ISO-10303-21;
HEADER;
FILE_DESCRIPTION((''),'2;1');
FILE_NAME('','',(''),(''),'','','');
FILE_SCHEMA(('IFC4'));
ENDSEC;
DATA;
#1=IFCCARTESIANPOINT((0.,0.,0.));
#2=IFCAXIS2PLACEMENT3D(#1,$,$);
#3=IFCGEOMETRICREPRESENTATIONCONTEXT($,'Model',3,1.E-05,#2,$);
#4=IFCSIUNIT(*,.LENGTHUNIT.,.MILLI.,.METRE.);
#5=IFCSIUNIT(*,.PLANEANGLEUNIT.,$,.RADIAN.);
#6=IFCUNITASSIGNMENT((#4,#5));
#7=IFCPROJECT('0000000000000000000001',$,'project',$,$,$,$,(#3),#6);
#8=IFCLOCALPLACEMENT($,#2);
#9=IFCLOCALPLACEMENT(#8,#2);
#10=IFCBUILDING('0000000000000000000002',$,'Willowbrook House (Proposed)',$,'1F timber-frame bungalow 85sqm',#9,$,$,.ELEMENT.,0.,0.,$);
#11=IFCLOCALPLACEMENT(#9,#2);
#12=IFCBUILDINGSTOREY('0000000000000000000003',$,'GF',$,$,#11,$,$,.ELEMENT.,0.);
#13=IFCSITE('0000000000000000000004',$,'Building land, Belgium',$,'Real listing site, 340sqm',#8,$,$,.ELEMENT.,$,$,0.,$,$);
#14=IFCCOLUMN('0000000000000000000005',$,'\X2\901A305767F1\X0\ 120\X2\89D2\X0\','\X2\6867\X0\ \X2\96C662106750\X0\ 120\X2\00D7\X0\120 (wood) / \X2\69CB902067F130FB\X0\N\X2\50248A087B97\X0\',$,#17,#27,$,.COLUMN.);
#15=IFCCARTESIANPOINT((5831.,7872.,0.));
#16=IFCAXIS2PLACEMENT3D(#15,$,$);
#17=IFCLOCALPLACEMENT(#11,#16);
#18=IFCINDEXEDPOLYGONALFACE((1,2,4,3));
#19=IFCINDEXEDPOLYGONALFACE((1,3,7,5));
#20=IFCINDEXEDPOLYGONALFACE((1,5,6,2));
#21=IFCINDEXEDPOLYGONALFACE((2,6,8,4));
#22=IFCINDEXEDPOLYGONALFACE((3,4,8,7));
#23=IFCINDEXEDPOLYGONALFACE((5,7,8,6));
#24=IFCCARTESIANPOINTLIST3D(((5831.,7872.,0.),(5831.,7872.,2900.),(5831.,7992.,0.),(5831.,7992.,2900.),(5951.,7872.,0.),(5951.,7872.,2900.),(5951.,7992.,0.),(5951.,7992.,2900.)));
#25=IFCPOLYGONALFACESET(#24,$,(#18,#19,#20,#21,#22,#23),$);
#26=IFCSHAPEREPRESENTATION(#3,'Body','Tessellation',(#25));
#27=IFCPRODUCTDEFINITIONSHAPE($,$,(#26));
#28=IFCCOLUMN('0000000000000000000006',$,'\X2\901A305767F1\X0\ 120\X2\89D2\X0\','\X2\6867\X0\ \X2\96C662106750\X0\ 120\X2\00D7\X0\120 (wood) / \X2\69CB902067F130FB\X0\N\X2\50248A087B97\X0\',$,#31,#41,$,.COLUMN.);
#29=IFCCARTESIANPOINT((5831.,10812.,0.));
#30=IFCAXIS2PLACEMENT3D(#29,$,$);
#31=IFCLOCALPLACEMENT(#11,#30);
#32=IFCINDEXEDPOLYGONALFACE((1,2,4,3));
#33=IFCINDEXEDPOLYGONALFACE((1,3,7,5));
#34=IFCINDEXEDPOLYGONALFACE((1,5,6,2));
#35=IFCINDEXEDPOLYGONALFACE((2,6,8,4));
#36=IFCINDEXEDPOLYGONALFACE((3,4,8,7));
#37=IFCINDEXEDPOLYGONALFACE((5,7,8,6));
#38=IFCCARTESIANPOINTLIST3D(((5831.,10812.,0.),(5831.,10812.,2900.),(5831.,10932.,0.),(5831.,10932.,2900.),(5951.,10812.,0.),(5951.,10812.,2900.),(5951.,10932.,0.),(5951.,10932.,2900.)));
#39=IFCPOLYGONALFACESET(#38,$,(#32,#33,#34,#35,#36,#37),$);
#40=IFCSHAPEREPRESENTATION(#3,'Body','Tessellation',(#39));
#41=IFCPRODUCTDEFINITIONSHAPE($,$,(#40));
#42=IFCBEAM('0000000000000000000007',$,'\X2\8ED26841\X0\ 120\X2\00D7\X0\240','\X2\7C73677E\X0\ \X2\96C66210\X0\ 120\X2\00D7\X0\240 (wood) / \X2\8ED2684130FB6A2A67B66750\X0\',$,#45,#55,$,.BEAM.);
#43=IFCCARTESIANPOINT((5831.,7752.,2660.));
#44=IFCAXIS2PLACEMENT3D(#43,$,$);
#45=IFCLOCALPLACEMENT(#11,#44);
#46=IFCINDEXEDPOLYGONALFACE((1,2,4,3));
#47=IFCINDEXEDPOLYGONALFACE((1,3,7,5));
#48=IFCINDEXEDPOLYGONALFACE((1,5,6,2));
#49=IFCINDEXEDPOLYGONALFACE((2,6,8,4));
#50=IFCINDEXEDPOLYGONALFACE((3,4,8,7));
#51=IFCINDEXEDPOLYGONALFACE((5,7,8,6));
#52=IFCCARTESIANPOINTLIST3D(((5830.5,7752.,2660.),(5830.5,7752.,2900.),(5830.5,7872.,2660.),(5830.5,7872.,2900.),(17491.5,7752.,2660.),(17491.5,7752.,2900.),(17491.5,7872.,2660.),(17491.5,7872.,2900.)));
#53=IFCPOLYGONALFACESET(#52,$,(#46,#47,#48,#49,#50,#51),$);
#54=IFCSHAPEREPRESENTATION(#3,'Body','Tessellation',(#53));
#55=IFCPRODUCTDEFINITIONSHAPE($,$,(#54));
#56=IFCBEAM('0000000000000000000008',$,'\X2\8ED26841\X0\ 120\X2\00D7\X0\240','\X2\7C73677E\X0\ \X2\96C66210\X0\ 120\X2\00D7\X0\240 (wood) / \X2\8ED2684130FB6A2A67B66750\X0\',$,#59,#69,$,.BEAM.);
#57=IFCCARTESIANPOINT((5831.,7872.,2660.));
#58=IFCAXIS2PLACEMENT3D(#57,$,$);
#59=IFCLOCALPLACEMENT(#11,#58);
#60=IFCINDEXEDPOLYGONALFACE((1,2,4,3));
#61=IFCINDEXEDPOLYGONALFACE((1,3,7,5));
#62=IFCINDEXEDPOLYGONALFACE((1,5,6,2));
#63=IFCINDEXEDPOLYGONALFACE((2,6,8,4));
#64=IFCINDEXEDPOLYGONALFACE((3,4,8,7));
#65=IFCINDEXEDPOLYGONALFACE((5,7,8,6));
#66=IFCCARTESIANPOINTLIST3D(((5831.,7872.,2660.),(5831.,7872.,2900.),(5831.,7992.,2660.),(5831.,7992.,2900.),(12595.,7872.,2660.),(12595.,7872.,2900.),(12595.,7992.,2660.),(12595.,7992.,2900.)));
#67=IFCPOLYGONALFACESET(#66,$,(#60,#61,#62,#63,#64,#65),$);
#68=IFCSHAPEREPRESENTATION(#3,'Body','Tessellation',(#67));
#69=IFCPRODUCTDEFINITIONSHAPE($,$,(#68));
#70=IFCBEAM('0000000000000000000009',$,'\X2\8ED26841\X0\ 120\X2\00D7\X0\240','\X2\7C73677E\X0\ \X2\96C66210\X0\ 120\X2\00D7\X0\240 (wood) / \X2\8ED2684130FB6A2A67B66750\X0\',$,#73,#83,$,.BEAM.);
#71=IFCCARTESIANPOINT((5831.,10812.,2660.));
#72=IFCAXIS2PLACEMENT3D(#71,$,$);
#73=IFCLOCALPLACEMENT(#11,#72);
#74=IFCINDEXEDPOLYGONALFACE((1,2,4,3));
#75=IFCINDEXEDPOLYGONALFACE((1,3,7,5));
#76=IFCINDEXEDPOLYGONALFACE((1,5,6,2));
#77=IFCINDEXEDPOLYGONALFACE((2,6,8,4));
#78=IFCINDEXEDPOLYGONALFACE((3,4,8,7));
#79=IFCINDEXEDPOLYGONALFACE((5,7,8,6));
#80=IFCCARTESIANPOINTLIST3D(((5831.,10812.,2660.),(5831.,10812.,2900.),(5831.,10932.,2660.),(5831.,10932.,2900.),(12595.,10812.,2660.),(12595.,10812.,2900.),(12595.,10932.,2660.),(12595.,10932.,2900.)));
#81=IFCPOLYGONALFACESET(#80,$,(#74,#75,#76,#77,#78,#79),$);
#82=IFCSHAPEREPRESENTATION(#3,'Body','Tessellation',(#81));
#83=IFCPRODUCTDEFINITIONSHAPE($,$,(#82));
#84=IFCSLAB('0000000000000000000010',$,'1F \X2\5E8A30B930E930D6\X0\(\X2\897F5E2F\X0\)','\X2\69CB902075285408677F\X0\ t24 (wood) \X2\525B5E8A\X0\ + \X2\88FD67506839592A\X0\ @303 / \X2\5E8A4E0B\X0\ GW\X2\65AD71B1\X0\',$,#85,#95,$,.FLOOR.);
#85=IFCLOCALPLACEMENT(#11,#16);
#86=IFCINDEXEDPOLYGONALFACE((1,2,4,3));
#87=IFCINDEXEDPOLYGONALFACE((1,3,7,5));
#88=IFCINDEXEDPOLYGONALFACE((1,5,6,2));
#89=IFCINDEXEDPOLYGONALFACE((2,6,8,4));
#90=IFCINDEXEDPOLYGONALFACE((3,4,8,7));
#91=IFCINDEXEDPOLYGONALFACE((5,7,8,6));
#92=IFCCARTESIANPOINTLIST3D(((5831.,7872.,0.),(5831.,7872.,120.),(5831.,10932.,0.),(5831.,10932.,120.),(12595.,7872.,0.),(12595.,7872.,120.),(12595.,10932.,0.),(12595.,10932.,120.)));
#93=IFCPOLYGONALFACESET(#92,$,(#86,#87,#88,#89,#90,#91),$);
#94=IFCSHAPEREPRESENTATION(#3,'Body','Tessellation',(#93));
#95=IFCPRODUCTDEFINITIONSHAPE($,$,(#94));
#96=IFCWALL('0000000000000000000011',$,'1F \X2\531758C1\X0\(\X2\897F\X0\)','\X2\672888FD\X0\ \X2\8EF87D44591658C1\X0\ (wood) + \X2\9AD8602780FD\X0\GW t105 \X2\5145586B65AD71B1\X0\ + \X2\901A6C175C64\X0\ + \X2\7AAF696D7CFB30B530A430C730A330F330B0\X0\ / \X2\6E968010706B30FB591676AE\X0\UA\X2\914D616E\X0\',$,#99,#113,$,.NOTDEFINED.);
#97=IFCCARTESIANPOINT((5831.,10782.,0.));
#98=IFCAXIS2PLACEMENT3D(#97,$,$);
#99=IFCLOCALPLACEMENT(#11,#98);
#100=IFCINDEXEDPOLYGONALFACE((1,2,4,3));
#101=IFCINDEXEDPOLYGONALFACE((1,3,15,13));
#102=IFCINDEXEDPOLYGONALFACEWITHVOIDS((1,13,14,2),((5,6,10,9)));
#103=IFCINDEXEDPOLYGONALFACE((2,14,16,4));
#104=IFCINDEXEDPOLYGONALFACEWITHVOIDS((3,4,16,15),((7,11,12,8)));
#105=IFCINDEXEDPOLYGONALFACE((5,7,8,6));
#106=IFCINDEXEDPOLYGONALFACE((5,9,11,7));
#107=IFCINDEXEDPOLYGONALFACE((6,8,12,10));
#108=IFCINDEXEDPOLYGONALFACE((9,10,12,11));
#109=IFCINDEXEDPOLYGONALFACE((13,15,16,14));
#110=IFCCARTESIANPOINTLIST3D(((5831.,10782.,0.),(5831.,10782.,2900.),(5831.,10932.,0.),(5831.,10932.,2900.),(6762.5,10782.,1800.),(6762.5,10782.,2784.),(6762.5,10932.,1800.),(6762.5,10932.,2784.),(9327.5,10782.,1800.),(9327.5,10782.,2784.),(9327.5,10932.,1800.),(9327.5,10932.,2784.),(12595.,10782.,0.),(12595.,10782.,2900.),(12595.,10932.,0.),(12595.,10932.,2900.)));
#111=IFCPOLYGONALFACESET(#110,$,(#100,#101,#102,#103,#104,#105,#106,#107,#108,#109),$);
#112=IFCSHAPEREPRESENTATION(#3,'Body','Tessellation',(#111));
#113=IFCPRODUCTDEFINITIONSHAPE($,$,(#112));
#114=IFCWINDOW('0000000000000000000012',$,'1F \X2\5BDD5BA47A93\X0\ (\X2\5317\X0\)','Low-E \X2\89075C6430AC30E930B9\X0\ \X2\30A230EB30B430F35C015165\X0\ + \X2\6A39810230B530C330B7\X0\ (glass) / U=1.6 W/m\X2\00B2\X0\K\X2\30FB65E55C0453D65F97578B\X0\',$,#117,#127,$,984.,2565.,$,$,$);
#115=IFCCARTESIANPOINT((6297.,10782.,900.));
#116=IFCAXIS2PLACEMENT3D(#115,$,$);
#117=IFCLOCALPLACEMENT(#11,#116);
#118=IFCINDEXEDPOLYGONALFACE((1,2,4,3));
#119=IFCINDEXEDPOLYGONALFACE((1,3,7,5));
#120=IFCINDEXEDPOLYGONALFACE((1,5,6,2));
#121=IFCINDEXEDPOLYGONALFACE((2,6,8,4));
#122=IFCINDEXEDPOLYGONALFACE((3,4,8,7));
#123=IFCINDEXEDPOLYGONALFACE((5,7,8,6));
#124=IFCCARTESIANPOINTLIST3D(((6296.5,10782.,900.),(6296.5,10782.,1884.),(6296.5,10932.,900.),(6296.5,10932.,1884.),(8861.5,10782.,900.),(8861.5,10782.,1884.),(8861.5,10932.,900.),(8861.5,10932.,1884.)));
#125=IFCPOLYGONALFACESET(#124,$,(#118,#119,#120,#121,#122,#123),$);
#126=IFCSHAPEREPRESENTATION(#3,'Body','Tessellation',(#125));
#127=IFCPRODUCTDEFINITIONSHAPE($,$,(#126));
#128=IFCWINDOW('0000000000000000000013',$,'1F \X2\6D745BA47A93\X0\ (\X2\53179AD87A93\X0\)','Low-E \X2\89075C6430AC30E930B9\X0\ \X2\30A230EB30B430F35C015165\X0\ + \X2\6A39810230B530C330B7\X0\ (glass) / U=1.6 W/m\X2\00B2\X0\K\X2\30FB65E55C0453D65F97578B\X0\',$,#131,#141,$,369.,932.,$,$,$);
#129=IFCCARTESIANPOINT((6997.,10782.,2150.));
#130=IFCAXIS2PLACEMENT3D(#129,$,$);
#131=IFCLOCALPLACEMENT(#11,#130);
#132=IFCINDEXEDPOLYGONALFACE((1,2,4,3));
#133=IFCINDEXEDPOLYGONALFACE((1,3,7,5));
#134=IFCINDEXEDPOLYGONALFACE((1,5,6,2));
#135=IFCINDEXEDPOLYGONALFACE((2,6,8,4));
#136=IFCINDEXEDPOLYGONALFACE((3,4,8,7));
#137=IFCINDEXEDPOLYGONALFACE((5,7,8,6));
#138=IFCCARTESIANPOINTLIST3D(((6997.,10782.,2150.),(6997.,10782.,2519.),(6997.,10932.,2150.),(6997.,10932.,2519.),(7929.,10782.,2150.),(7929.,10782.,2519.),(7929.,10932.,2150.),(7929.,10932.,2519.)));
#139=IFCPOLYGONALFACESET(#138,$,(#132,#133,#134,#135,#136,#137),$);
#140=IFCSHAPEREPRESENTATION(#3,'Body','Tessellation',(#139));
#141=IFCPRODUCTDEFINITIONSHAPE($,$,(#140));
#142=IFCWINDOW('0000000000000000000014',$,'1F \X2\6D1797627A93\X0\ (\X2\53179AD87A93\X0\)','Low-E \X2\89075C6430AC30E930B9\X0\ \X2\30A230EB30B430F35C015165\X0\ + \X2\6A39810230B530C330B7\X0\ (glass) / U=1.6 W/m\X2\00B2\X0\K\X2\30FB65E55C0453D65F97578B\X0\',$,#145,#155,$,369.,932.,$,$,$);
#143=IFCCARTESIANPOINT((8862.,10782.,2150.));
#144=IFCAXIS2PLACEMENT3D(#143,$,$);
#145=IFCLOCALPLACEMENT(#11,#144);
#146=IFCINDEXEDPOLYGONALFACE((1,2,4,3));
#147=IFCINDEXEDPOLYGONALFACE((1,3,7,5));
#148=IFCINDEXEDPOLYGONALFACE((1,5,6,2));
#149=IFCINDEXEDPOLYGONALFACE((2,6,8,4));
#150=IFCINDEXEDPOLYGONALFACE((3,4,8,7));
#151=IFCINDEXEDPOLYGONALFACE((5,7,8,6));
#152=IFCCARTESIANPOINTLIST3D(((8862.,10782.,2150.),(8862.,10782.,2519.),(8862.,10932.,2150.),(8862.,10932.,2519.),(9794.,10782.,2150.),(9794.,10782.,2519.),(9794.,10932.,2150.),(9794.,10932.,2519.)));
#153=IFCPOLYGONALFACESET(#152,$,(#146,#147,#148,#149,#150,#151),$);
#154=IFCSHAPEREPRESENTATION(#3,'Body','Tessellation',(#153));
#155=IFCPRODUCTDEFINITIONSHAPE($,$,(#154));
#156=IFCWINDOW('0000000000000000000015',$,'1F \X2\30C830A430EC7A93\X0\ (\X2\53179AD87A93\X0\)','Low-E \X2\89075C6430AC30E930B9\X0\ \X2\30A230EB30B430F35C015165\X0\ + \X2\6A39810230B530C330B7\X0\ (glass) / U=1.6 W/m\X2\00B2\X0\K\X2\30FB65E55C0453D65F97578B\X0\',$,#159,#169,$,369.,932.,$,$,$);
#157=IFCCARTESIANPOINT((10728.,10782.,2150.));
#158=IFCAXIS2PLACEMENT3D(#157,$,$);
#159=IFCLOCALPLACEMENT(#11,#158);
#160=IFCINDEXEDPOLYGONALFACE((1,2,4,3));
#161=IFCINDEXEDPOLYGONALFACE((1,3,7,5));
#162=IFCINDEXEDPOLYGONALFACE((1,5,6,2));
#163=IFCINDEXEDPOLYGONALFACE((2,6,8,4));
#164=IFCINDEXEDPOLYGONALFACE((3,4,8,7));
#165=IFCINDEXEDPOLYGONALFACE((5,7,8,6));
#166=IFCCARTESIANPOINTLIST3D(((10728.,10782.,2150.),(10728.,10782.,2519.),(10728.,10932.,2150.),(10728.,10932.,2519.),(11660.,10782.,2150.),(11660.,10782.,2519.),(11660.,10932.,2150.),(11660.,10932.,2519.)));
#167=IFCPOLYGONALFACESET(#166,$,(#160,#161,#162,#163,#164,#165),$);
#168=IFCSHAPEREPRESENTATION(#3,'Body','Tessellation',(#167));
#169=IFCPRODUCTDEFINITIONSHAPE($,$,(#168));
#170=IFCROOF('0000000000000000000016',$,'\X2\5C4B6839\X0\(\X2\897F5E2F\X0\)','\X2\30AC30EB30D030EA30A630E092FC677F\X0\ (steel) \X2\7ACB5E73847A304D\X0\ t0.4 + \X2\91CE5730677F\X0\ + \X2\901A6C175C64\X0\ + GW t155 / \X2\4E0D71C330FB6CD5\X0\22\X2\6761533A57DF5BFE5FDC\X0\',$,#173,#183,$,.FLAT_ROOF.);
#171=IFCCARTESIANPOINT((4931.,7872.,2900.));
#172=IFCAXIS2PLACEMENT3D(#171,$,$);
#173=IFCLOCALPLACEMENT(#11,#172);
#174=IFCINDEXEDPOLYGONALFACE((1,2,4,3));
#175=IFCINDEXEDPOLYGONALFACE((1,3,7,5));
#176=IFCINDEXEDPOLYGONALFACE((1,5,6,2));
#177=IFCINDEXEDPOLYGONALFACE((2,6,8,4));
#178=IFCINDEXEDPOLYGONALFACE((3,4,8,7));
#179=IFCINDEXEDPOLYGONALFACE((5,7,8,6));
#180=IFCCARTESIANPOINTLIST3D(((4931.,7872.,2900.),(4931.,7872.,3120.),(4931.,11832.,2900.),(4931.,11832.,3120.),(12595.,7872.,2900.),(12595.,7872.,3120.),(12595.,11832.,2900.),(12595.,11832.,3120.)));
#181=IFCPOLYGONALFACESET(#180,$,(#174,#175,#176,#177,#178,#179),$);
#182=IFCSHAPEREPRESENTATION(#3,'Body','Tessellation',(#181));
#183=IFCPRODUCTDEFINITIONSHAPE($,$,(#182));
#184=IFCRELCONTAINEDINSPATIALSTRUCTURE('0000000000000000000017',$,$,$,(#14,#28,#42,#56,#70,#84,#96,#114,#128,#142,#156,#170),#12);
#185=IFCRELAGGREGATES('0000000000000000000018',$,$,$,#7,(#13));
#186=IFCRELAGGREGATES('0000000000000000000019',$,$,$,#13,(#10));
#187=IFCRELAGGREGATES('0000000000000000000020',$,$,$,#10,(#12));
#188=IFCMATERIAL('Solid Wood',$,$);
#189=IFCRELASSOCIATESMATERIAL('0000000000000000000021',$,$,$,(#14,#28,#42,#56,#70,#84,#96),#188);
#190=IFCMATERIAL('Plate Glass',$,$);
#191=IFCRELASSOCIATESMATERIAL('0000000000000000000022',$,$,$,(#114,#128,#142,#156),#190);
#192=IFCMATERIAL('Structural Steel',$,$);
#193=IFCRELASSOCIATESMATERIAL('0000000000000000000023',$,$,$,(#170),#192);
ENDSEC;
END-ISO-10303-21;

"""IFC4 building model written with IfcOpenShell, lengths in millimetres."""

from ifc_helpers import new_model, si_unit, frame, frame_2d, origin, place, context, project, spatial, rectangle, extrude, material, element, fill, save


model = new_model("IFC4")

# Units and contexts
model_context = context("Model", 3, precision=1e-05, world=origin())
ifc_project = project(units=[si_unit("LENGTHUNIT", "METRE", prefix="MILLI"), si_unit("PLANEANGLEUNIT", "RADIAN")], contexts=[model_context])

# Site, building, storey
site_placement = place(None, origin())
site = spatial("IfcSite", under=ifc_project, at=site_placement, Name="Building land, Belgium", ObjectType="Real listing site, 340sqm", CompositionType="ELEMENT", RefElevation=0.0)
building_placement = place(site_placement, origin())
building = spatial("IfcBuilding", under=site, at=building_placement, Name="Willowbrook House (Proposed)", ObjectType="1F timber-frame bungalow 85sqm", CompositionType="ELEMENT", ElevationOfRefHeight=0.0, ElevationOfTerrain=0.0)
storey_placement = place(building_placement, origin())
storey = spatial("IfcBuildingStorey", under=building, at=storey_placement, Name="GF", CompositionType="ELEMENT", Elevation=0.0)

# Columns
ifc_material_1 = material(Name="Solid Wood")
column_1_placement = place(storey_placement, frame((5831.0, 7872.0, 0.0)))
element("IfcColumn", 1, at=column_1_placement, inside=storey, material=ifc_material_1, Name="通し柱 120角", Description="桧 集成材 120×120 (wood) / 構造柱・N値計算", PredefinedType="COLUMN", context=model_context, shape_type="SweptSolid", body=[
    extrude(rectangle(XDim=120.0, YDim=120.0, at=frame_2d((60.0, 60.0))), frame((5831.0, 7872.0, 0.0)), (0.0, 0.0, 1.0), 2900.0),
])
column_2_placement = place(storey_placement, frame((5831.0, 10812.0, 0.0)))
element("IfcColumn", 2, at=column_2_placement, inside=storey, material=ifc_material_1, Name="通し柱 120角", Description="桧 集成材 120×120 (wood) / 構造柱・N値計算", PredefinedType="COLUMN", context=model_context, shape_type="SweptSolid", body=[
    extrude(rectangle(XDim=120.0, YDim=120.0, at=frame_2d((60.0, 60.0))), frame((5831.0, 10812.0, 0.0)), (0.0, 0.0, 1.0), 2900.0),
])

# Beams
beam_1_placement = place(storey_placement, frame((5831.0, 7752.0, 2660.0)))
element("IfcBeam", 3, at=beam_1_placement, inside=storey, material=ifc_material_1, Name="軒桁 120×240", Description="米松 集成 120×240 (wood) / 軒桁・横架材", PredefinedType="BEAM", context=model_context, shape_type="SweptSolid", body=[
    extrude(rectangle(XDim=11661.0, YDim=120.0, at=frame_2d((5830.0, 60.0))), frame((5831.0, 7752.0, 2660.0)), (0.0, 0.0, 1.0), 240.0),
])
beam_2_placement = place(storey_placement, frame((5831.0, 7872.0, 2660.0)))
element("IfcBeam", 4, at=beam_2_placement, inside=storey, material=ifc_material_1, Name="軒桁 120×240", Description="米松 集成 120×240 (wood) / 軒桁・横架材", PredefinedType="BEAM", context=model_context, shape_type="SweptSolid", body=[
    extrude(rectangle(XDim=6764.0, YDim=120.0, at=frame_2d((3382.0, 60.0))), frame((5831.0, 7872.0, 2660.0)), (0.0, 0.0, 1.0), 240.0),
])
beam_3_placement = place(storey_placement, frame((5831.0, 10812.0, 2660.0)))
element("IfcBeam", 5, at=beam_3_placement, inside=storey, material=ifc_material_1, Name="軒桁 120×240", Description="米松 集成 120×240 (wood) / 軒桁・横架材", PredefinedType="BEAM", context=model_context, shape_type="SweptSolid", body=[
    extrude(rectangle(XDim=6764.0, YDim=120.0, at=frame_2d((3382.0, 60.0))), frame((5831.0, 10812.0, 2660.0)), (0.0, 0.0, 1.0), 240.0),
])

# Slab
slab_placement = place(storey_placement, frame((5831.0, 7872.0, 0.0)))
element("IfcSlab", 6, at=slab_placement, inside=storey, material=ifc_material_1, Name="1F 床スラブ(西帯)", Description="構造用合板 t24 (wood) 剛床 + 製材根太 @303 / 床下 GW断熱", PredefinedType="FLOOR", context=model_context, shape_type="SweptSolid", body=[
    extrude(rectangle(XDim=6764.0, YDim=3060.0, at=frame_2d((3382.0, 1530.0))), frame((5831.0, 7872.0, 0.0)), (0.0, 0.0, 1.0), 120.0),
])

# Wall, openings, windows
wall_1_placement = place(storey_placement, frame((5831.0, 10782.0, 0.0)))
wall_1 = element("IfcWall", 7, at=wall_1_placement, inside=storey, material=ifc_material_1, Name="1F 北壁(西)", Description="木製 軸組外壁 (wood) + 高性能GW t105 充填断熱 + 通気層 + 窯業系サイディング / 準耐火・外皮UA配慮", PredefinedType="NOTDEFINED", context=model_context, shape_type="SweptSolid", body=[
    extrude(rectangle(XDim=6764.0, YDim=150.0, at=frame_2d((3382.0, 75.0))), frame((5831.0, 10782.0, 0.0)), (0.0, 0.0, 1.0), 2900.0),
])
opening_1_placement = place(storey_placement, frame((6297.0, 10782.0, 900.0)))
opening_1 = element("IfcOpeningElement", 8, at=opening_1_placement, cuts=wall_1, PredefinedType="NOTDEFINED", context=model_context, shape_type="SweptSolid", body=[
    extrude(rectangle(XDim=2565.0, YDim=150.0, at=frame_2d((1282.0, 75.0))), frame((6297.0, 10782.0, 900.0)), (0.0, 0.0, 1.0), 984.0),
])
opening_2_placement = place(storey_placement, frame((6997.0, 10782.0, 2150.0)))
opening_2 = element("IfcOpeningElement", 9, at=opening_2_placement, cuts=wall_1, PredefinedType="NOTDEFINED", context=model_context, shape_type="SweptSolid", body=[
    extrude(rectangle(XDim=932.0, YDim=150.0, at=frame_2d((466.0, 75.0))), frame((6997.0, 10782.0, 2150.0)), (0.0, 0.0, 1.0), 369.0),
])
opening_3_placement = place(storey_placement, frame((8862.0, 10782.0, 2150.0)))
opening_3 = element("IfcOpeningElement", 10, at=opening_3_placement, cuts=wall_1, PredefinedType="NOTDEFINED", context=model_context, shape_type="SweptSolid", body=[
    extrude(rectangle(XDim=932.0, YDim=150.0, at=frame_2d((466.0, 75.0))), frame((8862.0, 10782.0, 2150.0)), (0.0, 0.0, 1.0), 369.0),
])
opening_4_placement = place(storey_placement, frame((10728.0, 10782.0, 2150.0)))
opening_4 = element("IfcOpeningElement", 11, at=opening_4_placement, cuts=wall_1, PredefinedType="NOTDEFINED", context=model_context, shape_type="SweptSolid", body=[
    extrude(rectangle(XDim=932.0, YDim=150.0, at=frame_2d((466.0, 75.0))), frame((10728.0, 10782.0, 2150.0)), (0.0, 0.0, 1.0), 369.0),
])
ifc_material_2 = material(Name="Plate Glass")
window_1_placement = place(storey_placement, frame((6297.0, 10782.0, 900.0)))
window_1 = element("IfcWindow", 12, at=window_1_placement, inside=storey, material=ifc_material_2, Name="1F 寝室窓 (北)", Description="Low-E 複層ガラス アルゴン封入 + 樹脂サッシ (glass) / U=1.6 W/m²K・日射取得型", OverallHeight=984.0, OverallWidth=2565.0, context=model_context, shape_type="SweptSolid", body=[
    extrude(rectangle(XDim=2565.0, YDim=150.0, at=frame_2d((1282.0, 75.0))), frame((6297.0, 10782.0, 900.0)), (0.0, 0.0, 1.0), 984.0),
])
fill(opening_1, window_1)
window_2_placement = place(storey_placement, frame((6997.0, 10782.0, 2150.0)))
window_2 = element("IfcWindow", 13, at=window_2_placement, inside=storey, material=ifc_material_2, Name="1F 浴室窓 (北高窓)", Description="Low-E 複層ガラス アルゴン封入 + 樹脂サッシ (glass) / U=1.6 W/m²K・日射取得型", OverallHeight=369.0, OverallWidth=932.0, context=model_context, shape_type="SweptSolid", body=[
    extrude(rectangle(XDim=932.0, YDim=150.0, at=frame_2d((466.0, 75.0))), frame((6997.0, 10782.0, 2150.0)), (0.0, 0.0, 1.0), 369.0),
])
fill(opening_2, window_2)
window_3_placement = place(storey_placement, frame((8862.0, 10782.0, 2150.0)))
window_3 = element("IfcWindow", 14, at=window_3_placement, inside=storey, material=ifc_material_2, Name="1F 洗面窓 (北高窓)", Description="Low-E 複層ガラス アルゴン封入 + 樹脂サッシ (glass) / U=1.6 W/m²K・日射取得型", OverallHeight=369.0, OverallWidth=932.0, context=model_context, shape_type="SweptSolid", body=[
    extrude(rectangle(XDim=932.0, YDim=150.0, at=frame_2d((466.0, 75.0))), frame((8862.0, 10782.0, 2150.0)), (0.0, 0.0, 1.0), 369.0),
])
fill(opening_3, window_3)
window_4_placement = place(storey_placement, frame((10728.0, 10782.0, 2150.0)))
window_4 = element("IfcWindow", 15, at=window_4_placement, inside=storey, material=ifc_material_2, Name="1F トイレ窓 (北高窓)", Description="Low-E 複層ガラス アルゴン封入 + 樹脂サッシ (glass) / U=1.6 W/m²K・日射取得型", OverallHeight=369.0, OverallWidth=932.0, context=model_context, shape_type="SweptSolid", body=[
    extrude(rectangle(XDim=932.0, YDim=150.0, at=frame_2d((466.0, 75.0))), frame((10728.0, 10782.0, 2150.0)), (0.0, 0.0, 1.0), 369.0),
])
fill(opening_4, window_4)

# Roof
ifc_material_3 = material(Name="Structural Steel")
roof_placement = place(storey_placement, frame((4931.0, 7872.0, 2900.0)))
element("IfcRoof", 16, at=roof_placement, inside=storey, material=ifc_material_3, Name="屋根(西帯)", Description="ガルバリウム鋼板 (steel) 立平葺き t0.4 + 野地板 + 通気層 + GW t155 / 不燃・法22条区域対応", PredefinedType="FLAT_ROOF", context=model_context, shape_type="SweptSolid", body=[
    extrude(rectangle(XDim=7664.0, YDim=3960.0, at=frame_2d((3832.0, 1980.0))), frame((4931.0, 7872.0, 2900.0)), (0.0, 0.0, 1.0), 220.0),
])

save(model, "model.ifc")
